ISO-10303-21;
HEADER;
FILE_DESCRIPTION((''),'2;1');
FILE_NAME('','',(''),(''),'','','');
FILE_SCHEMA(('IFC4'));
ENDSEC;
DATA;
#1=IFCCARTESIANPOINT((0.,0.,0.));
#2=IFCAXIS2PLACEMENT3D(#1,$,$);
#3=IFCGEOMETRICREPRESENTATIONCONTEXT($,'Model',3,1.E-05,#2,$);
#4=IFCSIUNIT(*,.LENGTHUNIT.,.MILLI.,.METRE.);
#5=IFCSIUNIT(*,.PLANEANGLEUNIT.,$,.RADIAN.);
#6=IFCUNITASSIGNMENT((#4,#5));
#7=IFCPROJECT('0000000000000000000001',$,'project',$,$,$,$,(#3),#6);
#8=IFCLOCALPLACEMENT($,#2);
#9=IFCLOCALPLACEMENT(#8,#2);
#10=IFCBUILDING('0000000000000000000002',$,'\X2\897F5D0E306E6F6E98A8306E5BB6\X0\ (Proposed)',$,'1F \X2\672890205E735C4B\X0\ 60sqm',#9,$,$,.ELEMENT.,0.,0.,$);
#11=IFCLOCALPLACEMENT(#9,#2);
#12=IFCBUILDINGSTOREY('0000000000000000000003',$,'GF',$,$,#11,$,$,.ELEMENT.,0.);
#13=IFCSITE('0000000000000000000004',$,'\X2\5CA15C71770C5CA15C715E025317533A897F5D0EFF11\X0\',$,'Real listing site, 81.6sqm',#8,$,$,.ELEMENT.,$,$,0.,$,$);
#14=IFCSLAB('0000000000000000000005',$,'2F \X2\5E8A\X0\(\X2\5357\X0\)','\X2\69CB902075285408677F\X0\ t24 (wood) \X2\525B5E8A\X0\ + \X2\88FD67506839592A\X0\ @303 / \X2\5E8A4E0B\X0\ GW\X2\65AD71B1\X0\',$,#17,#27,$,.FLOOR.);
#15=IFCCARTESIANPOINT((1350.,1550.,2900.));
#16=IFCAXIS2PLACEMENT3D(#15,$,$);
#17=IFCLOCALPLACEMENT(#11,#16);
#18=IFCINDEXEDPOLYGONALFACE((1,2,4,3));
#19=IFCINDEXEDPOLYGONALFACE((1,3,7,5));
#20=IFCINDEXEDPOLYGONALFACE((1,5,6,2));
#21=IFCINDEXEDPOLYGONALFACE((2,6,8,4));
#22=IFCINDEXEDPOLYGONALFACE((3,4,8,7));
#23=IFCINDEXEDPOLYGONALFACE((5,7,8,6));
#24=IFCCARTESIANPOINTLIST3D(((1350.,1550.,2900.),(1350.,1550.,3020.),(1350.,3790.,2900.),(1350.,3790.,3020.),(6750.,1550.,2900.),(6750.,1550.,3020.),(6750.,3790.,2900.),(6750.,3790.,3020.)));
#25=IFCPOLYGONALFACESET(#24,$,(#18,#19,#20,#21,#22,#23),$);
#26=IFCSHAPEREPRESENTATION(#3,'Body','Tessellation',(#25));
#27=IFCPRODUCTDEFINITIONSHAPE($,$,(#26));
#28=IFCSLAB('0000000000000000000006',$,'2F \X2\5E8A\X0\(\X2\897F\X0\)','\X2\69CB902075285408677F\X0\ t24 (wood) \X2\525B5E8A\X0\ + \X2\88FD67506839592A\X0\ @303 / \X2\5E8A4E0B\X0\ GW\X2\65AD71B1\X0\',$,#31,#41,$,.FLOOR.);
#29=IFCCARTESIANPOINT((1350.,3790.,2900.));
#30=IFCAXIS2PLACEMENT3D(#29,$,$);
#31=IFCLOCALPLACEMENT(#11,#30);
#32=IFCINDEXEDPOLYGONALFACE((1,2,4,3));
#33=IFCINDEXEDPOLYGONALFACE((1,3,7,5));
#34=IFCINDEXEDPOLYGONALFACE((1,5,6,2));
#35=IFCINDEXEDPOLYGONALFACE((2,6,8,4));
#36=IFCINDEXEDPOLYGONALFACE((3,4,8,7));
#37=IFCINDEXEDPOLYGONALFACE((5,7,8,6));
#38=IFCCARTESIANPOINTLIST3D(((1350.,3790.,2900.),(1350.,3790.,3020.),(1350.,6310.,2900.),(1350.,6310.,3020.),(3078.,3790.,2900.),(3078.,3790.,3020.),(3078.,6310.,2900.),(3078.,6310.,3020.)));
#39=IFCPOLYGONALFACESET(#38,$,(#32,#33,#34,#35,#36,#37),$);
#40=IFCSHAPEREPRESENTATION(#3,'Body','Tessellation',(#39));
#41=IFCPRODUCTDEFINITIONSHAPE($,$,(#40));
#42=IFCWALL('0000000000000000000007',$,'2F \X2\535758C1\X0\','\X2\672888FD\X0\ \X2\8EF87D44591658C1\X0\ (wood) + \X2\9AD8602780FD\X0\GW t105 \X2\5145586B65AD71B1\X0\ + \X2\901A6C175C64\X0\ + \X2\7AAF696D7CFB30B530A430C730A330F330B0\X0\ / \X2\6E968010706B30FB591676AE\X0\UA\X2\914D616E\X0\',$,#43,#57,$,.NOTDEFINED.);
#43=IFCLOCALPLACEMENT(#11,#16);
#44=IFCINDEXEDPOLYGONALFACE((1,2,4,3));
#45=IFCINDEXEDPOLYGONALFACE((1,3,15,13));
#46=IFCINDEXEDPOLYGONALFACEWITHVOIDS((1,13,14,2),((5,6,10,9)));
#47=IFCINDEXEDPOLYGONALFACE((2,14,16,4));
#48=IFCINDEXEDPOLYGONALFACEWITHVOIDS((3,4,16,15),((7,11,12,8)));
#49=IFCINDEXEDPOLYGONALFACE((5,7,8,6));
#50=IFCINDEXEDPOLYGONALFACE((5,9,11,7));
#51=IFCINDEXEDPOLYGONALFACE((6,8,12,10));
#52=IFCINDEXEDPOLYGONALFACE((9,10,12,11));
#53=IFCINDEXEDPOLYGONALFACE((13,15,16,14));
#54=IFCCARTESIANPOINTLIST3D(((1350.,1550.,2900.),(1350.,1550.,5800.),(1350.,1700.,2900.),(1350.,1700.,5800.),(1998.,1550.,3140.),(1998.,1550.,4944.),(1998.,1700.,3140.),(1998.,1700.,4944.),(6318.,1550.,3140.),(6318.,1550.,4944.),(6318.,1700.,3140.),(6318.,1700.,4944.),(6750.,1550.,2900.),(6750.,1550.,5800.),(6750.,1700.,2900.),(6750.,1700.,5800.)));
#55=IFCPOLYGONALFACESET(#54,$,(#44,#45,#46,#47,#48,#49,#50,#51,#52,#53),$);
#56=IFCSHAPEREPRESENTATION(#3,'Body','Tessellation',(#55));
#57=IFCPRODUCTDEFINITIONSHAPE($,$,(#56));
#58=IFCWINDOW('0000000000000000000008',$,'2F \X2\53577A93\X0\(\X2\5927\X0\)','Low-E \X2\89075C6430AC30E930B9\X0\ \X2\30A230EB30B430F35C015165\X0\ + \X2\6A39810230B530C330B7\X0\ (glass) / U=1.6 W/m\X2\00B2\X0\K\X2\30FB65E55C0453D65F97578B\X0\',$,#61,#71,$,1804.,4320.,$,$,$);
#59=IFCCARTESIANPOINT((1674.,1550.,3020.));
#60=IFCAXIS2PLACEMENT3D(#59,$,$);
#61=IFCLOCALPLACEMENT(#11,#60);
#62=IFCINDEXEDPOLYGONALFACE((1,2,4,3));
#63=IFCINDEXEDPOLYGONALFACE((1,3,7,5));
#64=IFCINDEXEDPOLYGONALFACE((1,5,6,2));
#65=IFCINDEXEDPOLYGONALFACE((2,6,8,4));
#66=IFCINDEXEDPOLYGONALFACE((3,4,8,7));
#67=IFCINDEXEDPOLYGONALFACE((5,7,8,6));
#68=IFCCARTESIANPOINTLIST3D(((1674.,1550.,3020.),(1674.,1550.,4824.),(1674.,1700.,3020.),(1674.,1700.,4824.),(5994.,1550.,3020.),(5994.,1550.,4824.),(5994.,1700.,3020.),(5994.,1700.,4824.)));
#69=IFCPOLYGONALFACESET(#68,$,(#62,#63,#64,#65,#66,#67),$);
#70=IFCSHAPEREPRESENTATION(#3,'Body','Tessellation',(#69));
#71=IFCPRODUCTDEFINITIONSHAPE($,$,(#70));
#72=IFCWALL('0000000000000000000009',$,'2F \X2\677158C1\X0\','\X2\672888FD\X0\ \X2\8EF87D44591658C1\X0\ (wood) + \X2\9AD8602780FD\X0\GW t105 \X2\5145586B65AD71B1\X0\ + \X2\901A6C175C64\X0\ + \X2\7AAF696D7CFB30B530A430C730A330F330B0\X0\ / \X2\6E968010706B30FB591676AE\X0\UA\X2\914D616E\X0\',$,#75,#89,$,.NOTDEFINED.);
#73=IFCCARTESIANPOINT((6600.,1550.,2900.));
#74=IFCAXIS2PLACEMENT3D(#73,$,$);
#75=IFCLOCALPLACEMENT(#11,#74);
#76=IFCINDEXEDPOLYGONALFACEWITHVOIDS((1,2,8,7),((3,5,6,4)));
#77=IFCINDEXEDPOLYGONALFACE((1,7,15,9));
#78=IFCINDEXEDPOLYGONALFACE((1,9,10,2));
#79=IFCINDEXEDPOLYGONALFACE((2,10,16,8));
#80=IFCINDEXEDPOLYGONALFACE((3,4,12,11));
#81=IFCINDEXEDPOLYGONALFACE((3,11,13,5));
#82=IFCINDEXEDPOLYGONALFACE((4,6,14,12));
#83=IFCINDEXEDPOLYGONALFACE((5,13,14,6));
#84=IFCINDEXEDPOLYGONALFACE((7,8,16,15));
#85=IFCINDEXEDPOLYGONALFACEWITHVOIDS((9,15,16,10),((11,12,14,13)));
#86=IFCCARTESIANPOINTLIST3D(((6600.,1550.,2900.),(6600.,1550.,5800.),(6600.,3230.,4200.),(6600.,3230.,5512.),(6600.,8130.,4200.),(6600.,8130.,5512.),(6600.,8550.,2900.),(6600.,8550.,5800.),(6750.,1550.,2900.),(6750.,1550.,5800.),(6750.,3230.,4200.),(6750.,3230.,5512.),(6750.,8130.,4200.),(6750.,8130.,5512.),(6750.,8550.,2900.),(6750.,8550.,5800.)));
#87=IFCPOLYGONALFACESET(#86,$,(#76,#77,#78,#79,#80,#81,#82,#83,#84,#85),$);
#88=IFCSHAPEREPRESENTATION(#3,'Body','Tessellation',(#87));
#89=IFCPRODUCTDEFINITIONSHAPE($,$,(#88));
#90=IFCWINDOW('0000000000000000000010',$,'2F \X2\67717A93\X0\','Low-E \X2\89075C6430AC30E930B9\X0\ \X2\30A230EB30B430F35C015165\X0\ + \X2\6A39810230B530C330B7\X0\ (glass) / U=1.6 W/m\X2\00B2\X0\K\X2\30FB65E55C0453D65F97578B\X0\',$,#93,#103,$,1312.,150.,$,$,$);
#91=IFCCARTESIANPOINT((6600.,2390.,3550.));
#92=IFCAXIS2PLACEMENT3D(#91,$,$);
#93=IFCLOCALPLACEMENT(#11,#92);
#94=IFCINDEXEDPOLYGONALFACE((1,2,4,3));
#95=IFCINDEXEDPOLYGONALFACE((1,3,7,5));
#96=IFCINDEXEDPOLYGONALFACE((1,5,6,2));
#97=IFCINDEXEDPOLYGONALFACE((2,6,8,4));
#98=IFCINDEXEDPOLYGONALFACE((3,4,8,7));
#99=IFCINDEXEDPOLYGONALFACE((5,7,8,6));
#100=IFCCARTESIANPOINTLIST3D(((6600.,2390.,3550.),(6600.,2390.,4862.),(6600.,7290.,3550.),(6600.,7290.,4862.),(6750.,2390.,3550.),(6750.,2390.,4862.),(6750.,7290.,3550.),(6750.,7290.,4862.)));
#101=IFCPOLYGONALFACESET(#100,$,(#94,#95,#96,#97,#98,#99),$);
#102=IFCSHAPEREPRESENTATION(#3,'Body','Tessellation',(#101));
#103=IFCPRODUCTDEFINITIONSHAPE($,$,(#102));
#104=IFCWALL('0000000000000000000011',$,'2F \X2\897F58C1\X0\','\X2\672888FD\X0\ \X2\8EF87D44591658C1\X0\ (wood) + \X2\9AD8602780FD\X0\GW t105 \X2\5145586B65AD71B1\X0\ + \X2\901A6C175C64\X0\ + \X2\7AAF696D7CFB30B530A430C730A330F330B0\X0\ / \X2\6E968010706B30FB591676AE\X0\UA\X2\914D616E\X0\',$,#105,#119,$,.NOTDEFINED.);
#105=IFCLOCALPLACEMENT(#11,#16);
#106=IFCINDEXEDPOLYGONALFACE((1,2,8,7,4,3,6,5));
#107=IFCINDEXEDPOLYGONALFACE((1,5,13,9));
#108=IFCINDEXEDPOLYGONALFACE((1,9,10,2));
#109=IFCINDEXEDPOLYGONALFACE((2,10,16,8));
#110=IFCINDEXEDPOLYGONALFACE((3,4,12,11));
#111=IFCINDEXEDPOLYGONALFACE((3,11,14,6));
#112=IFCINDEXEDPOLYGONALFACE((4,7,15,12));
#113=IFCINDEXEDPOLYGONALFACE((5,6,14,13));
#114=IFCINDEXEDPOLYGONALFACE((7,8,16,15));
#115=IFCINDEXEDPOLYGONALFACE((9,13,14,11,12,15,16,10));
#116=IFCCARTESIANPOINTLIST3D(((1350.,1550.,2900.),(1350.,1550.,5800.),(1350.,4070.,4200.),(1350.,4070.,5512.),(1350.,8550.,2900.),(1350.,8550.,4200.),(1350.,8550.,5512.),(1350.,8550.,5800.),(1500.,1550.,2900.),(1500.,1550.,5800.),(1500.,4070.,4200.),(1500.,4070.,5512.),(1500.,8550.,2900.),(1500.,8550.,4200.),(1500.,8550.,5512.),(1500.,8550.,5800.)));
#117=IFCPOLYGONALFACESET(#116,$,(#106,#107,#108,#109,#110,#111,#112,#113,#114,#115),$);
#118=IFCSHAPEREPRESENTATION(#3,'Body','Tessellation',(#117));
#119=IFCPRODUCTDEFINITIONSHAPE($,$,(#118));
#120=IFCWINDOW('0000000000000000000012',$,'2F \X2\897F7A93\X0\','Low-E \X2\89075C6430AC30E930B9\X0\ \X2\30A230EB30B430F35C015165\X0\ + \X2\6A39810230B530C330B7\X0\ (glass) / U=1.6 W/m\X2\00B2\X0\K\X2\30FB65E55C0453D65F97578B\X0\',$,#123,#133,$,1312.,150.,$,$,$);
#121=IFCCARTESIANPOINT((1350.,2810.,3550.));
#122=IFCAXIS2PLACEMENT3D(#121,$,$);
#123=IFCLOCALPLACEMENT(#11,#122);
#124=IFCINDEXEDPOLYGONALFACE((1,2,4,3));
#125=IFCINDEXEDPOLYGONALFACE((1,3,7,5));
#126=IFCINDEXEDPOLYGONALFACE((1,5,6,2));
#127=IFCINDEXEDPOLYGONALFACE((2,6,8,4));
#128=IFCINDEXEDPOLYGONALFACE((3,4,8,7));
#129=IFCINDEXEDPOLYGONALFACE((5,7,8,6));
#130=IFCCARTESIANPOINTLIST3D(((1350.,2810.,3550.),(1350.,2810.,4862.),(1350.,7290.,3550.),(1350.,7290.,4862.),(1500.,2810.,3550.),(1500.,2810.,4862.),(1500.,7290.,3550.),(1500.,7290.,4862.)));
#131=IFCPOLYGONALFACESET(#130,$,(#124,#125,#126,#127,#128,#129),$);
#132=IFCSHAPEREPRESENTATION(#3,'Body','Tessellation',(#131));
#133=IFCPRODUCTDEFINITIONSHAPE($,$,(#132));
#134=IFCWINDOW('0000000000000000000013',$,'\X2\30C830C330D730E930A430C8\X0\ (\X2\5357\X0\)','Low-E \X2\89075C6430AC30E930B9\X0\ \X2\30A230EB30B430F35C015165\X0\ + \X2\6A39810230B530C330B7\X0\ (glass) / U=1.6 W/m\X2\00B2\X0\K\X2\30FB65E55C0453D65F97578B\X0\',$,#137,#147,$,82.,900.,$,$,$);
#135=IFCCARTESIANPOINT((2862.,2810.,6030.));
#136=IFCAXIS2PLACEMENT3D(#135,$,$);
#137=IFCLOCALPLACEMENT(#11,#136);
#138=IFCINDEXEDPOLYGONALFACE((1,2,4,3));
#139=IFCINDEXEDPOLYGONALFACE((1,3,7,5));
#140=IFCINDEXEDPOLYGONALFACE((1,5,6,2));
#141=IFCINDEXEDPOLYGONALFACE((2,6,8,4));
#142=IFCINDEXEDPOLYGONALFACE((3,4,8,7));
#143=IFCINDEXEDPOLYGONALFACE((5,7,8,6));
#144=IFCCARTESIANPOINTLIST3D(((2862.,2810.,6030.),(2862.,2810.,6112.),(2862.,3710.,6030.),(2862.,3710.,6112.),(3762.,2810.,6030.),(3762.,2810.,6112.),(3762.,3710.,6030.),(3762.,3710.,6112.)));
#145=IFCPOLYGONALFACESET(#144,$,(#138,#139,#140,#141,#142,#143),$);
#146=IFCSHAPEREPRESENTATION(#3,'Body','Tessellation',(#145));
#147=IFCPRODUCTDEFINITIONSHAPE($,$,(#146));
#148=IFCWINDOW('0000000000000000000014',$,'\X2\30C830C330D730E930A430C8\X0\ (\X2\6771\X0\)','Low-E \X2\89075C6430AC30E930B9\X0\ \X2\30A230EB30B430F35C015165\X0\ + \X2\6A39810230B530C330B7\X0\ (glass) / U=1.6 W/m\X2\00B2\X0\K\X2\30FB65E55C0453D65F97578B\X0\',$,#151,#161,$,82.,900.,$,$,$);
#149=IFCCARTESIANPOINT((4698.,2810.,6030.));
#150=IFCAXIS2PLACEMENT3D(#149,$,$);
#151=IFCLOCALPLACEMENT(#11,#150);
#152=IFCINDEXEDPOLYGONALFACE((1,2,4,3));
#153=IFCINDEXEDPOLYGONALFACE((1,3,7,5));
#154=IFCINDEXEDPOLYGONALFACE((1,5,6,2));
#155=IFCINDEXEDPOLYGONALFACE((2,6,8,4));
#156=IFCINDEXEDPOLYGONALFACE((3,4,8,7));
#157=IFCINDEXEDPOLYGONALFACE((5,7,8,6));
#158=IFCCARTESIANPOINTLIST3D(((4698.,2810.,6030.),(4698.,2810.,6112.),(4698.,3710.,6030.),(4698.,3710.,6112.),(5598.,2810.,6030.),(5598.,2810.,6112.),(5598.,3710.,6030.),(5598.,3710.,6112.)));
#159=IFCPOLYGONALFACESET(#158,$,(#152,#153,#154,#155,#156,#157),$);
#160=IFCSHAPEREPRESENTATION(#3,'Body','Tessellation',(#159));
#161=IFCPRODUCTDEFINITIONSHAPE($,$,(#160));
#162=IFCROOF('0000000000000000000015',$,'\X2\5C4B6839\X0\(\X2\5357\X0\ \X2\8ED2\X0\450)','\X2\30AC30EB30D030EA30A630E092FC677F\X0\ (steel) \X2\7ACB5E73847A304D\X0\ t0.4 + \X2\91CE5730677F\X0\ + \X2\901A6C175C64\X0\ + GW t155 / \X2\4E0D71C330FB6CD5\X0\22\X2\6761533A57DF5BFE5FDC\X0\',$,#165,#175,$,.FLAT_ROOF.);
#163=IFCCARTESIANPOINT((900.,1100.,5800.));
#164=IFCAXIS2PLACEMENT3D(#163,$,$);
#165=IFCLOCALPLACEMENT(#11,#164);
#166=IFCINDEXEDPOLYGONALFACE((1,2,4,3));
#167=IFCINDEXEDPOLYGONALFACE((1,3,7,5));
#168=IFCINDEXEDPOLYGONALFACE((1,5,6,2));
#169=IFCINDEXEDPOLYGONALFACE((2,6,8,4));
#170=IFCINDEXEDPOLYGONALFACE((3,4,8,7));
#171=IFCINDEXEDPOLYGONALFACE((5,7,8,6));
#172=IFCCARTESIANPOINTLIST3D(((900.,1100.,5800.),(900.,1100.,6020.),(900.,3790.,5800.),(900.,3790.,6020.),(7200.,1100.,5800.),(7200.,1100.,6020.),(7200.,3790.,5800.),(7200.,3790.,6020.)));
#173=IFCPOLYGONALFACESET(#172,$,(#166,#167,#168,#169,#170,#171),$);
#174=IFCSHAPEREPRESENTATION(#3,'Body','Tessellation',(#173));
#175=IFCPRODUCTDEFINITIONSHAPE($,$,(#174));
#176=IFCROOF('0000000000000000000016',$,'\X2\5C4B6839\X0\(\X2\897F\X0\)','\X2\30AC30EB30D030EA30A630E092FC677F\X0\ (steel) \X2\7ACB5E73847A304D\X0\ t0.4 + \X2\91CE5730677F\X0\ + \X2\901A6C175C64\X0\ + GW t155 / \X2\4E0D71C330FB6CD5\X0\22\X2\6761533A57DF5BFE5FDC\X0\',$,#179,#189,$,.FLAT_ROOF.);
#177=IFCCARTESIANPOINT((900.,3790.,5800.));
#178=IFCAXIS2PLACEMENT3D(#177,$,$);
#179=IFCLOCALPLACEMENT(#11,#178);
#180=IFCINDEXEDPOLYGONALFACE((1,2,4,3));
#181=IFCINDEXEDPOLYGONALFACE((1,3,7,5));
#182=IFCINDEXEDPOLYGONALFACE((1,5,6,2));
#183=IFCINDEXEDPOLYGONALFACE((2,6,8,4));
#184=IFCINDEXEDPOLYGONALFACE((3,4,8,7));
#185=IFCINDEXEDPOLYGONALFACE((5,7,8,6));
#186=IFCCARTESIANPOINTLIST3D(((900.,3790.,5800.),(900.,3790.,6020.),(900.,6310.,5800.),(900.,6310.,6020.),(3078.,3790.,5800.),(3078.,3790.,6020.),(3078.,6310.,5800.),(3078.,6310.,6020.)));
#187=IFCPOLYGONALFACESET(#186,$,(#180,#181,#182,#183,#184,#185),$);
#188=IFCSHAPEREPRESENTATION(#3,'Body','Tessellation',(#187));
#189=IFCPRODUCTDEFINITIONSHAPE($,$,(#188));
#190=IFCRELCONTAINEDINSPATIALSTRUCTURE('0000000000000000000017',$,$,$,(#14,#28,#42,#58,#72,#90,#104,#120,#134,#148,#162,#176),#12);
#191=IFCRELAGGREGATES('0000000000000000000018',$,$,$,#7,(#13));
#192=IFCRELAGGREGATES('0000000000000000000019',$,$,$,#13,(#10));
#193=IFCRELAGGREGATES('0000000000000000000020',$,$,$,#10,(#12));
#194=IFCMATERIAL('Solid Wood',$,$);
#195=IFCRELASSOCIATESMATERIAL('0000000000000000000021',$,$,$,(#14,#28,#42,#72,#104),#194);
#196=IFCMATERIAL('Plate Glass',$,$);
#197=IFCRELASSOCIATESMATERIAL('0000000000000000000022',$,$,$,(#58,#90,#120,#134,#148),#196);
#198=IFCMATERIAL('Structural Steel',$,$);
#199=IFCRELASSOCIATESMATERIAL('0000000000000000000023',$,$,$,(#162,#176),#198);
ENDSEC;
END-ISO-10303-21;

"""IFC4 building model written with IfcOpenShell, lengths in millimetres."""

from ifc_helpers import new_model, si_unit, frame, frame_2d, origin, place, context, project, spatial, rectangle, extrude, material, element, fill, save


model = new_model("IFC4")

# Units and contexts
model_context = context("Model", 3, precision=1e-05, world=origin())
ifc_project = project(units=[si_unit("LENGTHUNIT", "METRE", prefix="MILLI"), si_unit("PLANEANGLEUNIT", "RADIAN")], contexts=[model_context])

# Site, building, storey
site_placement = place(None, origin())
site = spatial("IfcSite", under=ifc_project, at=site_placement, Name="岡山県岡山市北区西崎１", ObjectType="Real listing site, 81.6sqm", CompositionType="ELEMENT", RefElevation=0.0)
building_placement = place(site_placement, origin())
building = spatial("IfcBuilding", under=site, at=building_placement, Name="西崎の潮風の家 (Proposed)", ObjectType="1F 木造平屋 60sqm", CompositionType="ELEMENT", ElevationOfRefHeight=0.0, ElevationOfTerrain=0.0)
storey_placement = place(building_placement, origin())
storey = spatial("IfcBuildingStorey", under=building, at=storey_placement, Name="GF", CompositionType="ELEMENT", Elevation=0.0)

# Slabs
ifc_material_1 = material(Name="Solid Wood")
slab_1_placement = place(storey_placement, frame((1350.0, 1550.0, 2900.0)))
element("IfcSlab", 1, at=slab_1_placement, inside=storey, material=ifc_material_1, Name="2F 床(南)", Description="構造用合板 t24 (wood) 剛床 + 製材根太 @303 / 床下 GW断熱", PredefinedType="FLOOR", context=model_context, shape_type="SweptSolid", body=[
    extrude(rectangle(XDim=5400.0, YDim=2240.0, at=frame_2d((2700.0, 1120.0))), frame((1350.0, 1550.0, 2900.0)), (0.0, 0.0, 1.0), 120.0),
])
slab_2_placement = place(storey_placement, frame((1350.0, 3790.0, 2900.0)))
element("IfcSlab", 2, at=slab_2_placement, inside=storey, material=ifc_material_1, Name="2F 床(西)", Description="構造用合板 t24 (wood) 剛床 + 製材根太 @303 / 床下 GW断熱", PredefinedType="FLOOR", context=model_context, shape_type="SweptSolid", body=[
    extrude(rectangle(XDim=1728.0, YDim=2520.0, at=frame_2d((864.0, 1260.0))), frame((1350.0, 3790.0, 2900.0)), (0.0, 0.0, 1.0), 120.0),
])

# Walls, openings, windows
wall_1_placement = place(storey_placement, frame((1350.0, 1550.0, 2900.0)))
wall_1 = element("IfcWall", 3, at=wall_1_placement, inside=storey, material=ifc_material_1, Name="2F 南壁", Description="木製 軸組外壁 (wood) + 高性能GW t105 充填断熱 + 通気層 + 窯業系サイディング / 準耐火・外皮UA配慮", PredefinedType="NOTDEFINED", context=model_context, shape_type="SweptSolid", body=[
    extrude(rectangle(XDim=5400.0, YDim=150.0, at=frame_2d((2700.0, 75.0))), frame((1350.0, 1550.0, 2900.0)), (0.0, 0.0, 1.0), 2900.0),
])
opening_1_placement = place(storey_placement, frame((1674.0, 1550.0, 3020.0)))
opening_1 = element("IfcOpeningElement", 4, at=opening_1_placement, cuts=wall_1, PredefinedType="NOTDEFINED", context=model_context, shape_type="SweptSolid", body=[
    extrude(rectangle(XDim=4320.0, YDim=150.0, at=frame_2d((2160.0, 75.0))), frame((1674.0, 1550.0, 3020.0)), (0.0, 0.0, 1.0), 1804.0),
])
ifc_material_2 = material(Name="Plate Glass")
window_1_placement = place(storey_placement, frame((1674.0, 1550.0, 3020.0)))
window_1 = element("IfcWindow", 5, at=window_1_placement, inside=storey, material=ifc_material_2, Name="2F 南窓(大)", Description="Low-E 複層ガラス アルゴン封入 + 樹脂サッシ (glass) / U=1.6 W/m²K・日射取得型", OverallHeight=1804.0, OverallWidth=4320.0, context=model_context, shape_type="SweptSolid", body=[
    extrude(rectangle(XDim=4320.0, YDim=150.0, at=frame_2d((2160.0, 75.0))), frame((1674.0, 1550.0, 3020.0)), (0.0, 0.0, 1.0), 1804.0),
])
fill(opening_1, window_1)
wall_2_placement = place(storey_placement, frame((6600.0, 1550.0, 2900.0)))
wall_2 = element("IfcWall", 6, at=wall_2_placement, inside=storey, material=ifc_material_1, Name="2F 東壁", Description="木製 軸組外壁 (wood) + 高性能GW t105 充填断熱 + 通気層 + 窯業系サイディング / 準耐火・外皮UA配慮", PredefinedType="NOTDEFINED", context=model_context, shape_type="SweptSolid", body=[
    extrude(rectangle(XDim=150.0, YDim=7000.0, at=frame_2d((75.0, 3500.0))), frame((6600.0, 1550.0, 2900.0)), (0.0, 0.0, 1.0), 2900.0),
])
opening_2_placement = place(storey_placement, frame((6600.0, 2390.0, 3550.0)))
opening_2 = element("IfcOpeningElement", 7, at=opening_2_placement, cuts=wall_2, PredefinedType="NOTDEFINED", context=model_context, shape_type="SweptSolid", body=[
    extrude(rectangle(XDim=150.0, YDim=4900.0, at=frame_2d((75.0, 2450.0))), frame((6600.0, 2390.0, 3550.0)), (0.0, 0.0, 1.0), 1312.0),
])
window_2_placement = place(storey_placement, frame((6600.0, 2390.0, 3550.0)))
window_2 = element("IfcWindow", 8, at=window_2_placement, inside=storey, material=ifc_material_2, Name="2F 東窓", Description="Low-E 複層ガラス アルゴン封入 + 樹脂サッシ (glass) / U=1.6 W/m²K・日射取得型", OverallHeight=1312.0, OverallWidth=150.0, context=model_context, shape_type="SweptSolid", body=[
    extrude(rectangle(XDim=150.0, YDim=4900.0, at=frame_2d((75.0, 2450.0))), frame((6600.0, 2390.0, 3550.0)), (0.0, 0.0, 1.0), 1312.0),
])
fill(opening_2, window_2)
wall_3_placement = place(storey_placement, frame((1350.0, 1550.0, 2900.0)))
wall_3 = element("IfcWall", 9, at=wall_3_placement, inside=storey, material=ifc_material_1, Name="2F 西壁", Description="木製 軸組外壁 (wood) + 高性能GW t105 充填断熱 + 通気層 + 窯業系サイディング / 準耐火・外皮UA配慮", PredefinedType="NOTDEFINED", context=model_context, shape_type="SweptSolid", body=[
    extrude(rectangle(XDim=150.0, YDim=7000.0, at=frame_2d((75.0, 3500.0))), frame((1350.0, 1550.0, 2900.0)), (0.0, 0.0, 1.0), 2900.0),
])
opening_3_placement = place(storey_placement, frame((1350.0, 2810.0, 3550.0)))
opening_3 = element("IfcOpeningElement", 10, at=opening_3_placement, cuts=wall_3, PredefinedType="NOTDEFINED", context=model_context, shape_type="SweptSolid", body=[
    extrude(rectangle(XDim=150.0, YDim=4480.0, at=frame_2d((75.0, 2240.0))), frame((1350.0, 2810.0, 3550.0)), (0.0, 0.0, 1.0), 1312.0),
])
window_3_placement = place(storey_placement, frame((1350.0, 2810.0, 3550.0)))
window_3 = element("IfcWindow", 11, at=window_3_placement, inside=storey, material=ifc_material_2, Name="2F 西窓", Description="Low-E 複層ガラス アルゴン封入 + 樹脂サッシ (glass) / U=1.6 W/m²K・日射取得型", OverallHeight=1312.0, OverallWidth=150.0, context=model_context, shape_type="SweptSolid", body=[
    extrude(rectangle(XDim=150.0, YDim=4480.0, at=frame_2d((75.0, 2240.0))), frame((1350.0, 2810.0, 3550.0)), (0.0, 0.0, 1.0), 1312.0),
])
fill(opening_3, window_3)

# Windows
window_4_placement = place(storey_placement, frame((2862.0, 2810.0, 6030.0)))
element("IfcWindow", 12, at=window_4_placement, inside=storey, material=ifc_material_2, Name="トップライト (南)", Description="Low-E 複層ガラス アルゴン封入 + 樹脂サッシ (glass) / U=1.6 W/m²K・日射取得型", OverallHeight=82.0, OverallWidth=900.0, context=model_context, shape_type="SweptSolid", body=[
    extrude(rectangle(XDim=900.0, YDim=900.0, at=frame_2d((450.0, 450.0))), frame((2862.0, 2810.0, 6030.0)), (0.0, 0.0, 1.0), 82.0),
])
window_5_placement = place(storey_placement, frame((4698.0, 2810.0, 6030.0)))
element("IfcWindow", 13, at=window_5_placement, inside=storey, material=ifc_material_2, Name="トップライト (東)", Description="Low-E 複層ガラス アルゴン封入 + 樹脂サッシ (glass) / U=1.6 W/m²K・日射取得型", OverallHeight=82.0, OverallWidth=900.0, context=model_context, shape_type="SweptSolid", body=[
    extrude(rectangle(XDim=900.0, YDim=900.0, at=frame_2d((450.0, 450.0))), frame((4698.0, 2810.0, 6030.0)), (0.0, 0.0, 1.0), 82.0),
])

# Roofs
ifc_material_3 = material(Name="Structural Steel")
roof_1_placement = place(storey_placement, frame((900.0, 1100.0, 5800.0)))
element("IfcRoof", 14, at=roof_1_placement, inside=storey, material=ifc_material_3, Name="屋根(南 軒450)", Description="ガルバリウム鋼板 (steel) 立平葺き t0.4 + 野地板 + 通気層 + GW t155 / 不燃・法22条区域対応", PredefinedType="FLAT_ROOF", context=model_context, shape_type="SweptSolid", body=[
    extrude(rectangle(XDim=6300.0, YDim=2690.0, at=frame_2d((3150.0, 1345.0))), frame((900.0, 1100.0, 5800.0)), (0.0, 0.0, 1.0), 220.0),
])
roof_2_placement = place(storey_placement, frame((900.0, 3790.0, 5800.0)))
element("IfcRoof", 15, at=roof_2_placement, inside=storey, material=ifc_material_3, Name="屋根(西)", Description="ガルバリウム鋼板 (steel) 立平葺き t0.4 + 野地板 + 通気層 + GW t155 / 不燃・法22条区域対応", PredefinedType="FLAT_ROOF", context=model_context, shape_type="SweptSolid", body=[
    extrude(rectangle(XDim=2178.0, YDim=2520.0, at=frame_2d((1089.0, 1260.0))), frame((900.0, 3790.0, 5800.0)), (0.0, 0.0, 1.0), 220.0),
])

save(model, "model.ifc")
